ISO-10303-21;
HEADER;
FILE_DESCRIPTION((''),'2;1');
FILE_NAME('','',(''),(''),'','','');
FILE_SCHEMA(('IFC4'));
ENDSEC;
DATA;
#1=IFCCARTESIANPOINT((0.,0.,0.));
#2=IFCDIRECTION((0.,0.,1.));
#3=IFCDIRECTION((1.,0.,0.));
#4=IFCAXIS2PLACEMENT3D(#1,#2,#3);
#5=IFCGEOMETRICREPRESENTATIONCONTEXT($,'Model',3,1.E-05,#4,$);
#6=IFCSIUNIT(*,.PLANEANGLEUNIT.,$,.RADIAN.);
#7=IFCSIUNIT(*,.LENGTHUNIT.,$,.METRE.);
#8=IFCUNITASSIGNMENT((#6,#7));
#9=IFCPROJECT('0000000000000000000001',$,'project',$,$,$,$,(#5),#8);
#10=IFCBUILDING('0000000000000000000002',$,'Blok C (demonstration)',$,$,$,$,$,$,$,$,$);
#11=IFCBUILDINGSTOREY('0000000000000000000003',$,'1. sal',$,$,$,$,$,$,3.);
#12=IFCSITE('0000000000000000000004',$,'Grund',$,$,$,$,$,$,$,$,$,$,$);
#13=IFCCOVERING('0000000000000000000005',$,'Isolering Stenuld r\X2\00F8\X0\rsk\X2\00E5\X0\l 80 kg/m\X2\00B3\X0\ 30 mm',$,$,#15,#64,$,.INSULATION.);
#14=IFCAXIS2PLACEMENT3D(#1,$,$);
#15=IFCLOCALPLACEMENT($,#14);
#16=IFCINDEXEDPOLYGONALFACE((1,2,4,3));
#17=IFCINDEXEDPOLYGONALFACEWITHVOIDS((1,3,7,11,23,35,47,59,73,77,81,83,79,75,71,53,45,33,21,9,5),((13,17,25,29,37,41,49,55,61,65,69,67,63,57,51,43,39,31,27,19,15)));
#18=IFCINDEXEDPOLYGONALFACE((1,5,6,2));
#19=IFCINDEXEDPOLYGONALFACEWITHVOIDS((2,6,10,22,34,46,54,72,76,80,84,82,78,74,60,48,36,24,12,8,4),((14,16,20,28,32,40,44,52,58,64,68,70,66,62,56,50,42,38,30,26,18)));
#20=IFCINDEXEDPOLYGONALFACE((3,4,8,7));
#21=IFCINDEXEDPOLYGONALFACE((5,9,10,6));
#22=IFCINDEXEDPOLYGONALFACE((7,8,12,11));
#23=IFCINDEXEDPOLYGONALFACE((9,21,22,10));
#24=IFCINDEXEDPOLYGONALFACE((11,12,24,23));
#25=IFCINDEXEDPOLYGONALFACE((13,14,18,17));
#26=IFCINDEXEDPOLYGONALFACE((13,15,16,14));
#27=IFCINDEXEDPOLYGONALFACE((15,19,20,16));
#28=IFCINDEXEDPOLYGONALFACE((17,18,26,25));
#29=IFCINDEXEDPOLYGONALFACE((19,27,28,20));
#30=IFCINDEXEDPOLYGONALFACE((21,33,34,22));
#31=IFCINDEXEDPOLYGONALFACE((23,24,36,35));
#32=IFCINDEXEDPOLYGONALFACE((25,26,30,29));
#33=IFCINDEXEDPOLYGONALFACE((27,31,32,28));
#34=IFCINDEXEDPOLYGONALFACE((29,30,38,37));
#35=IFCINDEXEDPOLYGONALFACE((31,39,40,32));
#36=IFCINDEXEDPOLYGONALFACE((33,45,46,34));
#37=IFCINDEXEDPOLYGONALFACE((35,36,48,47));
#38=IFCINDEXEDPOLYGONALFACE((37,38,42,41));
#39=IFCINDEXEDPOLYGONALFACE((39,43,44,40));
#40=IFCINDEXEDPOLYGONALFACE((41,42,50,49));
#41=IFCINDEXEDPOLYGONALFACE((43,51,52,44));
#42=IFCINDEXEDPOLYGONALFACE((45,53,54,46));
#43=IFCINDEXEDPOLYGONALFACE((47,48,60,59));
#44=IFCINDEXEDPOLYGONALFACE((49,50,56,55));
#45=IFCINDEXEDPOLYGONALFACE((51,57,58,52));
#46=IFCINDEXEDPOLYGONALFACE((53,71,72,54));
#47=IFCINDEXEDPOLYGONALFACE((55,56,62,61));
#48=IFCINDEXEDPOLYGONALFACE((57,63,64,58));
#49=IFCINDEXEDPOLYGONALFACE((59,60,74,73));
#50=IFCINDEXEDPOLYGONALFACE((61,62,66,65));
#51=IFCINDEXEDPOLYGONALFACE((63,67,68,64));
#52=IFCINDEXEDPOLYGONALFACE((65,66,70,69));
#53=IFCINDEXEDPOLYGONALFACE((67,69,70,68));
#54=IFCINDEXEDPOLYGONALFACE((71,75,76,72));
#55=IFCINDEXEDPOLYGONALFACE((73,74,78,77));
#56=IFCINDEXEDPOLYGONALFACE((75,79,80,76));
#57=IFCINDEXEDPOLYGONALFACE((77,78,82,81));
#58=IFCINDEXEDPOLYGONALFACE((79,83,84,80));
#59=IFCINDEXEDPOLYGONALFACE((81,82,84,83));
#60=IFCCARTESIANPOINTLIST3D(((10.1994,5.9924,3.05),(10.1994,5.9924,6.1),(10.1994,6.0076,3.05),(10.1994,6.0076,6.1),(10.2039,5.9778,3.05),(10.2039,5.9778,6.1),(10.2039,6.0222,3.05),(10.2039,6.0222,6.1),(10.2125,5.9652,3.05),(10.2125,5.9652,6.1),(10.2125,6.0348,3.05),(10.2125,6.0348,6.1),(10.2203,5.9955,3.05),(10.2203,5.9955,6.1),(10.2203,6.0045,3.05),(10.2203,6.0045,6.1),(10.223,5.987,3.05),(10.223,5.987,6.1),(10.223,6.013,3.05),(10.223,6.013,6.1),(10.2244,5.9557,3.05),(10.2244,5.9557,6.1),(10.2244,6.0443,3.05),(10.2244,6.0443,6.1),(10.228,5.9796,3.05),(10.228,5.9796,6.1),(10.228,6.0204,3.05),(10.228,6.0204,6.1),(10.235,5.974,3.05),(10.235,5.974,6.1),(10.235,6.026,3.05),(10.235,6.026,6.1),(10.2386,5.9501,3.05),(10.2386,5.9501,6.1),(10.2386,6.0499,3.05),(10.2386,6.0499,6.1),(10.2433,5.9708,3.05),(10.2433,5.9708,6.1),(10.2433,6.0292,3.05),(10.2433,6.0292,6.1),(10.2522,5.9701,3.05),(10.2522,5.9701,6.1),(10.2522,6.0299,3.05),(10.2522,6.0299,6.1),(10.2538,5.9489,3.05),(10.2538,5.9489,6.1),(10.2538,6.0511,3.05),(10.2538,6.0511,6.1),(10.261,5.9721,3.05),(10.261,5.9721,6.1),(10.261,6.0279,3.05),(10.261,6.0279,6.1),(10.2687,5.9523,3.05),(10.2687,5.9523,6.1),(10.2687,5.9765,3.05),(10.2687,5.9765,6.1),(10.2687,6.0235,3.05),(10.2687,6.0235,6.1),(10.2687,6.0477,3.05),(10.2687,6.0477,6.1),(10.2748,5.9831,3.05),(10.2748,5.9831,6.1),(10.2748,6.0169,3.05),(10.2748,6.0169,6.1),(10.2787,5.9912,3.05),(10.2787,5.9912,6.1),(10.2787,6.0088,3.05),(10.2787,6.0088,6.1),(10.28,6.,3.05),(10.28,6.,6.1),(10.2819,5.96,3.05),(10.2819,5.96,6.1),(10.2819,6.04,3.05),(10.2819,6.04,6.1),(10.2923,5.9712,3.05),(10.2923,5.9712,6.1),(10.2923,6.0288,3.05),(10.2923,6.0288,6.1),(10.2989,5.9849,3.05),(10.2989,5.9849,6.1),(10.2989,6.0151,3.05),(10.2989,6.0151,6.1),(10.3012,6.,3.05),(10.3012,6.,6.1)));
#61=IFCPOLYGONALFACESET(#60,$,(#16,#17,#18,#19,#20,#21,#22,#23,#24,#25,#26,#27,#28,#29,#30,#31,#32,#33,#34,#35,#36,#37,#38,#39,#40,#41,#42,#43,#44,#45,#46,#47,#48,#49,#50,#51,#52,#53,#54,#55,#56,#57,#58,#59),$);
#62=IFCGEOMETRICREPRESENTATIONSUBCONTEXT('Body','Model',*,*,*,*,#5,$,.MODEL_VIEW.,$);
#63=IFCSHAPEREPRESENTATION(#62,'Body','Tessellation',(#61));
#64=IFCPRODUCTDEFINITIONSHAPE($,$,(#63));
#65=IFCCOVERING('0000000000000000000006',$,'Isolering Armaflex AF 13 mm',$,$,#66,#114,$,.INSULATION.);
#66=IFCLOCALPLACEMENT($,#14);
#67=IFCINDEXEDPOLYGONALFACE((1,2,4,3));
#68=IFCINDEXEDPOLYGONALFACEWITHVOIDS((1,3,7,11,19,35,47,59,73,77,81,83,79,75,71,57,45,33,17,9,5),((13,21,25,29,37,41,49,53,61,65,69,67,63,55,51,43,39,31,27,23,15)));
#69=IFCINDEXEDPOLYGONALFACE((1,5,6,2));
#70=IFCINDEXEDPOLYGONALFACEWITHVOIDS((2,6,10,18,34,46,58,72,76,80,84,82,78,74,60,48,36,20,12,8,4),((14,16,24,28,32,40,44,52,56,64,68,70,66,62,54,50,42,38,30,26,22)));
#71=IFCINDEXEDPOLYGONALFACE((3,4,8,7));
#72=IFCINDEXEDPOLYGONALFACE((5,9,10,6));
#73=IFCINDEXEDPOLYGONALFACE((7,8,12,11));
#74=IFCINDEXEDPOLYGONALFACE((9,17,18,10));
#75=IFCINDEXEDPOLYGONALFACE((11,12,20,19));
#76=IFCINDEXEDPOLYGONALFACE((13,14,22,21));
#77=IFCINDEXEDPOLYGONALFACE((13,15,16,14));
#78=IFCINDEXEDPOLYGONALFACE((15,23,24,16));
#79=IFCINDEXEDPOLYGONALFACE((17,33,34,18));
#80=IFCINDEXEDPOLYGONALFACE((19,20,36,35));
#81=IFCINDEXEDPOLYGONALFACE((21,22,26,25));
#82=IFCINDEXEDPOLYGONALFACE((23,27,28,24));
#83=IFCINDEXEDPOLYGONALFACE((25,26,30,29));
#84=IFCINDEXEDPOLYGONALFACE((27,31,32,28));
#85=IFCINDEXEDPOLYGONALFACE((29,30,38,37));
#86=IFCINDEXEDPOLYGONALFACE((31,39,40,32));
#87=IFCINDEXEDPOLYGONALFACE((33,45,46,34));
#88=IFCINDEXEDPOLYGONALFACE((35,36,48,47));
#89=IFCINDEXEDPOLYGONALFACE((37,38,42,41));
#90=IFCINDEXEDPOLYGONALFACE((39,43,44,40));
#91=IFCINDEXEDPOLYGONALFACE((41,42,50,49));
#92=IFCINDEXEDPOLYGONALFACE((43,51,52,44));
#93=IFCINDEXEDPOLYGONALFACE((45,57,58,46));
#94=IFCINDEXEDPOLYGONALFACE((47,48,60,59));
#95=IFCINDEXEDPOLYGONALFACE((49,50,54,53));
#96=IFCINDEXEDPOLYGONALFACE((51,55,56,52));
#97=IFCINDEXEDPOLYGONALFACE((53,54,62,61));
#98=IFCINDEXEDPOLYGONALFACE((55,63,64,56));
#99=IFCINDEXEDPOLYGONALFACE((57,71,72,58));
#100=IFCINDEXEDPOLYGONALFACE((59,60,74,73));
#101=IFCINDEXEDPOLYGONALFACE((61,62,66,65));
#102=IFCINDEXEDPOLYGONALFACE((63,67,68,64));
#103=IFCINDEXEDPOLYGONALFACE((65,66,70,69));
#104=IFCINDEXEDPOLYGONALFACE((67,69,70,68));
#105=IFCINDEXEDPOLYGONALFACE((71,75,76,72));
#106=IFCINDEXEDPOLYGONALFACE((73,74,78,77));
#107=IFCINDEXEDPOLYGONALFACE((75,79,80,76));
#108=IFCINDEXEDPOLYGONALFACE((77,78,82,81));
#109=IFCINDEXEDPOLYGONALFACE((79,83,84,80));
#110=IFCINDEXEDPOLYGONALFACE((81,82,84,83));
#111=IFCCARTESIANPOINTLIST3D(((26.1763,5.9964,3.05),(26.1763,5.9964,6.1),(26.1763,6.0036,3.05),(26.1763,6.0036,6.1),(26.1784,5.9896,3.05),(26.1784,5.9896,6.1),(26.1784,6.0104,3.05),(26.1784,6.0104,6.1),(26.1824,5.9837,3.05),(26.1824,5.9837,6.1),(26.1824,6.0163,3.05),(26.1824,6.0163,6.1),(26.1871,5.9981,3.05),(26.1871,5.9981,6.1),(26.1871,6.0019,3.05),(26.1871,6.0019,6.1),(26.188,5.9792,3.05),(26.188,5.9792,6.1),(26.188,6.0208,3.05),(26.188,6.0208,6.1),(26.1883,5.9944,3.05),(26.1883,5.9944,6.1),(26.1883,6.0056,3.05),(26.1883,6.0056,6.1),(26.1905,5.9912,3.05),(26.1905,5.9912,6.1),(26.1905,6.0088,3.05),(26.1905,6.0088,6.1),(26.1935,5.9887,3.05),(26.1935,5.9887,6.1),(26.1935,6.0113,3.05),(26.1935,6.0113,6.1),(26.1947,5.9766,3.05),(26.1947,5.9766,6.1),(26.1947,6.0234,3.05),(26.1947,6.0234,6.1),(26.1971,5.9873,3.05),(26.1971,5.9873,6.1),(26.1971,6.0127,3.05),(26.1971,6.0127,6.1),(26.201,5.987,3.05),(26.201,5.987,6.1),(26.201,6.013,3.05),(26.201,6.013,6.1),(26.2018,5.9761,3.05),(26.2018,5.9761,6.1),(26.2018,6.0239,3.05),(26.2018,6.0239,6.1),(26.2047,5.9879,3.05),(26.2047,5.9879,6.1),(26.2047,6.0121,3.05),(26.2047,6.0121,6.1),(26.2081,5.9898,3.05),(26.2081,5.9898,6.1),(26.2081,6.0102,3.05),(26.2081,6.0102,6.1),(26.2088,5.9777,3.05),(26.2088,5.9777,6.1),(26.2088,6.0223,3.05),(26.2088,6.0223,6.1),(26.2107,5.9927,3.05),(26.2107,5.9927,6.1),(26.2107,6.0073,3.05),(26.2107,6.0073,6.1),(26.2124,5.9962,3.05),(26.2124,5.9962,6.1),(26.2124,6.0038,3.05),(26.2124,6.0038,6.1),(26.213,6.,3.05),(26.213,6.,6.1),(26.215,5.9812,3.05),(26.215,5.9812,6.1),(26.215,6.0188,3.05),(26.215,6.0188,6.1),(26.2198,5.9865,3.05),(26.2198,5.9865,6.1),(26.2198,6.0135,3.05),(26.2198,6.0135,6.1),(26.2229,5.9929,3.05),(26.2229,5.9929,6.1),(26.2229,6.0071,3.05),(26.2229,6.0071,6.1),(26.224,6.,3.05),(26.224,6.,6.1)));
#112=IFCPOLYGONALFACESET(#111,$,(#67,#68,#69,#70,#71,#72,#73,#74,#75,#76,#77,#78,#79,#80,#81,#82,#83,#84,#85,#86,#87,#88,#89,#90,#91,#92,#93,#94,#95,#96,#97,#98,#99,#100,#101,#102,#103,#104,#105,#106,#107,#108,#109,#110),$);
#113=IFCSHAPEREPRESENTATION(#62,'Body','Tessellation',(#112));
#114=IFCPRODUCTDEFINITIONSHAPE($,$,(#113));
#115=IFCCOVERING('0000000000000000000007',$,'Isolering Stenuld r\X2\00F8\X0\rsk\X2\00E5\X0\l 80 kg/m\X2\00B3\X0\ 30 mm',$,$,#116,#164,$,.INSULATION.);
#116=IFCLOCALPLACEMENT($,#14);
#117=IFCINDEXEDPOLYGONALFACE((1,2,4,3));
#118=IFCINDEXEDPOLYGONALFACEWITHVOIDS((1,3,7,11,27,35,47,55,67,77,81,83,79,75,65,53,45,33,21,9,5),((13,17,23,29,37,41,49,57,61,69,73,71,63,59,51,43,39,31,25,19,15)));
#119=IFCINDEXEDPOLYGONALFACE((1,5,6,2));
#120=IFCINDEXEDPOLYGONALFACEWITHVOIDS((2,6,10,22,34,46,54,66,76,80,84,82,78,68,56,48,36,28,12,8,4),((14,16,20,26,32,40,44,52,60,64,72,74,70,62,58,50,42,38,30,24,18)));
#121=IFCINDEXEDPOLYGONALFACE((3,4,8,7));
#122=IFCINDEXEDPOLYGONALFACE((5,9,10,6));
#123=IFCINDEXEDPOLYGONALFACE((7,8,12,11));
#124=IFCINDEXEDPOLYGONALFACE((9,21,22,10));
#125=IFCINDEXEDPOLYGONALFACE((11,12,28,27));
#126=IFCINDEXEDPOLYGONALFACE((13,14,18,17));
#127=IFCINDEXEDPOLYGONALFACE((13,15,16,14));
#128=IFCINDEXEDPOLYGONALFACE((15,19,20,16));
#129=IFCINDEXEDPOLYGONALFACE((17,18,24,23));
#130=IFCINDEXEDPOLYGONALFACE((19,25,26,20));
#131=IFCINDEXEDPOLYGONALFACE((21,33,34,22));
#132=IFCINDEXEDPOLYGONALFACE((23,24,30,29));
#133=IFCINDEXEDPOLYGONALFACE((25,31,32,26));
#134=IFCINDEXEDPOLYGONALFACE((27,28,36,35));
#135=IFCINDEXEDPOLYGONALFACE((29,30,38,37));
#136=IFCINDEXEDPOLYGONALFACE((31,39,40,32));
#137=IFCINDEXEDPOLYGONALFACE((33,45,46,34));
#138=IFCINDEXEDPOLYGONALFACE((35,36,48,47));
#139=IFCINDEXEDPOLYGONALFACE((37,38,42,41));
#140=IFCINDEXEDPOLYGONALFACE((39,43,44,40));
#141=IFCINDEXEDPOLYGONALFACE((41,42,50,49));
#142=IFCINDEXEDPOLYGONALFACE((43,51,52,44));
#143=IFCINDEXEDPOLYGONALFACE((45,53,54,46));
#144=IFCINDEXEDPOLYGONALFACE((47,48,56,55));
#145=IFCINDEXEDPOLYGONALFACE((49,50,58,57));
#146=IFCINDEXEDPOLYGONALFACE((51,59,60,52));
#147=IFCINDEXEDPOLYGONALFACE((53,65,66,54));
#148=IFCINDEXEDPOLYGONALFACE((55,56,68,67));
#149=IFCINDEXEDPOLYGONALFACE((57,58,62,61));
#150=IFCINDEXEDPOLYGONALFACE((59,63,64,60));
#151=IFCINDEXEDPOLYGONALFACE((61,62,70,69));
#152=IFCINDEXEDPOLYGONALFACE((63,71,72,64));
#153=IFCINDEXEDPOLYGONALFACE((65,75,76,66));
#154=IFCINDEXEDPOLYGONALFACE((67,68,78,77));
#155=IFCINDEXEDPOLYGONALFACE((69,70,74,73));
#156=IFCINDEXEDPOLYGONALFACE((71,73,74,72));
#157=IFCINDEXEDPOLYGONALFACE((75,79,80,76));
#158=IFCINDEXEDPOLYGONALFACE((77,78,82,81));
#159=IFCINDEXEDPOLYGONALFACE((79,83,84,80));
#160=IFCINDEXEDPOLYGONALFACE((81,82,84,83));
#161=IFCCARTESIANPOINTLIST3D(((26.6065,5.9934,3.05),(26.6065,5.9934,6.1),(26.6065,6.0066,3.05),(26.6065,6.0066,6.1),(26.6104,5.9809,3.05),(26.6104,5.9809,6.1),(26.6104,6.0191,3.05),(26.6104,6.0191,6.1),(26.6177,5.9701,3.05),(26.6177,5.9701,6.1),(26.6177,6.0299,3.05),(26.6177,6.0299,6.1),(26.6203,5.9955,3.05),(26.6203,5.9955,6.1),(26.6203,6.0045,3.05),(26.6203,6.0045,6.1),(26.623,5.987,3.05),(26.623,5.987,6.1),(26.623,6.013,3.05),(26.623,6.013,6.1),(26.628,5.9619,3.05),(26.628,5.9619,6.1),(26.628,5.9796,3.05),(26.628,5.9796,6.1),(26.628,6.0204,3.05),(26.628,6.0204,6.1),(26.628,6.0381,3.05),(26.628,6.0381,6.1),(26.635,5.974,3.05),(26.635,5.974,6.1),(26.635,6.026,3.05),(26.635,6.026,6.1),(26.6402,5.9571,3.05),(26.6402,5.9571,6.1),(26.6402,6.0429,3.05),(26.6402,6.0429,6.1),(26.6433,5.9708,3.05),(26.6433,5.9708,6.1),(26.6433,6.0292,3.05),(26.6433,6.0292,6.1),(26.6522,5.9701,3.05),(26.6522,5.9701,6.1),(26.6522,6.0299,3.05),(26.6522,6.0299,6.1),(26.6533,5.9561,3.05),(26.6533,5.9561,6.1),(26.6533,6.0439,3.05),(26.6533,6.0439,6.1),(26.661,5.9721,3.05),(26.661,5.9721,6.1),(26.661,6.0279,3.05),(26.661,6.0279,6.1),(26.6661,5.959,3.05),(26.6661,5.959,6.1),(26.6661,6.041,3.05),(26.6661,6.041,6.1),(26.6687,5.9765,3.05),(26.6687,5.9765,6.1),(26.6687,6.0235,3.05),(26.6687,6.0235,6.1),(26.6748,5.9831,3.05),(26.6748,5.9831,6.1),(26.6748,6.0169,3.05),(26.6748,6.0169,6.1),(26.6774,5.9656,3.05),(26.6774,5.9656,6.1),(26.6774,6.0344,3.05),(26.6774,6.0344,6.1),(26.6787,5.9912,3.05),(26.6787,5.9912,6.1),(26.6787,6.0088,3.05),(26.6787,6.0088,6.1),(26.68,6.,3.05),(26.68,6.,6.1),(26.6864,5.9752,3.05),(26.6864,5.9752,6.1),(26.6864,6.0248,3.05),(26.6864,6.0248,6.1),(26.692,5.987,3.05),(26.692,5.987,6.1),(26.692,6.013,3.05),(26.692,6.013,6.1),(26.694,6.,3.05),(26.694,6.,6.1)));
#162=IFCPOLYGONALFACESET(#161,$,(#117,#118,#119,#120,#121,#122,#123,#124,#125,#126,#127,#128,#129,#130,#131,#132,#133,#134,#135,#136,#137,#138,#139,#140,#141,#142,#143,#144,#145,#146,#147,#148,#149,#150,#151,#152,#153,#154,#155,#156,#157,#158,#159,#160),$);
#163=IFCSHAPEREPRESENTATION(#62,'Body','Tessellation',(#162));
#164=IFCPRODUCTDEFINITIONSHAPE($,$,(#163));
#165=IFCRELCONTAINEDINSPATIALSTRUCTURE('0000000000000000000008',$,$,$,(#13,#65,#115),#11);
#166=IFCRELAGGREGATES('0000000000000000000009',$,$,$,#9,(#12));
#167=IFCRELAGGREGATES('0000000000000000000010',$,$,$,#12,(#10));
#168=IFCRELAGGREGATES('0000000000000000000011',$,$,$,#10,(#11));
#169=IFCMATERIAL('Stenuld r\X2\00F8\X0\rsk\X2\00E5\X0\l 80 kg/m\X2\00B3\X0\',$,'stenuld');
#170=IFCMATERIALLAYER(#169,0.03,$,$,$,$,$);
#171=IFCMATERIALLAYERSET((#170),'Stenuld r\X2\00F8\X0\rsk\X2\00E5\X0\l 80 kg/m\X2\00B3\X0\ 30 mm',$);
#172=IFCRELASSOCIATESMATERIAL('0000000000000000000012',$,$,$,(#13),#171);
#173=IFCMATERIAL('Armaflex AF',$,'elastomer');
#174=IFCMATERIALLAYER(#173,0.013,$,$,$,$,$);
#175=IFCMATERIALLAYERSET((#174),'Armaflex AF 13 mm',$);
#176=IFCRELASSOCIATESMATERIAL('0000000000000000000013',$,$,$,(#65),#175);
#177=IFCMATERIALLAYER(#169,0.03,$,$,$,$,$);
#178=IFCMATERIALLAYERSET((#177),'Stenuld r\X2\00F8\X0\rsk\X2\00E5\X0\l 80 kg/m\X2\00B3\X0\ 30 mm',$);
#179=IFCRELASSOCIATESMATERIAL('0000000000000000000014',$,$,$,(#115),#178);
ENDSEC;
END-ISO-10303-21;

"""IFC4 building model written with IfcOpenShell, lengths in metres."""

from ifc_helpers import new_model, si_unit, frame, origin_with_axes, place, context, subcontext, project, spatial, hollow_circle, extrude, material, layer, layer_set, element, save


model = new_model("IFC4")

# Units and contexts
model_context = context("Model", 3, precision=1e-05, world=origin_with_axes())
body_context = subcontext(model_context, "Body", "Model", "MODEL_VIEW")
ifc_project = project(units=[si_unit("PLANEANGLEUNIT", "RADIAN"), si_unit("LENGTHUNIT", "METRE")], contexts=[model_context])

# Site, building, storey
site = spatial("IfcSite", under=ifc_project, Name="Grund")
building = spatial("IfcBuilding", under=site, Name="Blok C (demonstration)")
storey = spatial("IfcBuildingStorey", under=building, Name="1. sal", Elevation=3.0)

# Coverings
ifc_material_1 = material(Name="Stenuld rørskål 80 kg/m³", Category="stenuld")
ifc_layer_1 = layer(ifc_material_1, 0.03)
ifc_layer_set_1 = layer_set([ifc_layer_1], Name="Stenuld rørskål 80 kg/m³ 30 mm")
covering_1_placement = place(None, origin_with_axes())
element("IfcCovering", 1, at=covering_1_placement, inside=storey, material=ifc_layer_set_1, Name="Isolering Stenuld rørskål 80 kg/m³ 30 mm", PredefinedType="INSULATION", context=body_context, shape_type="SweptSolid", body=[
    extrude(hollow_circle(Radius=0.0512, WallThickness=0.0212), frame((10.25, 6.0, 3.05), z_axis=(0.0, 0.0, 1.0), x_axis=(1.0, 0.0, 0.0)), (0.0, 0.0, 1.0), 3.05),
])
ifc_material_2 = material(Name="Armaflex AF", Category="elastomer")
ifc_layer_2 = layer(ifc_material_2, 0.013)
ifc_layer_set_2 = layer_set([ifc_layer_2], Name="Armaflex AF 13 mm")
covering_2_placement = place(None, origin_with_axes())
element("IfcCovering", 2, at=covering_2_placement, inside=storey, material=ifc_layer_set_2, Name="Isolering Armaflex AF 13 mm", PredefinedType="INSULATION", context=body_context, shape_type="SweptSolid", body=[
    extrude(hollow_circle(Radius=0.024, WallThickness=0.011), frame((26.2, 6.0, 3.05), z_axis=(0.0, 0.0, 1.0), x_axis=(1.0, 0.0, 0.0)), (0.0, 0.0, 1.0), 3.05),
])
ifc_layer_3 = layer(ifc_material_1, 0.03)
ifc_layer_set_3 = layer_set([ifc_layer_3], Name="Stenuld rørskål 80 kg/m³ 30 mm")
covering_3_placement = place(None, origin_with_axes())
element("IfcCovering", 3, at=covering_3_placement, inside=storey, material=ifc_layer_set_3, Name="Isolering Stenuld rørskål 80 kg/m³ 30 mm", PredefinedType="INSULATION", context=body_context, shape_type="SweptSolid", body=[
    extrude(hollow_circle(Radius=0.044, WallThickness=0.014), frame((26.65, 6.0, 3.05), z_axis=(0.0, 0.0, 1.0), x_axis=(1.0, 0.0, 0.0)), (0.0, 0.0, 1.0), 3.05),
])

save(model, "model.ifc")
